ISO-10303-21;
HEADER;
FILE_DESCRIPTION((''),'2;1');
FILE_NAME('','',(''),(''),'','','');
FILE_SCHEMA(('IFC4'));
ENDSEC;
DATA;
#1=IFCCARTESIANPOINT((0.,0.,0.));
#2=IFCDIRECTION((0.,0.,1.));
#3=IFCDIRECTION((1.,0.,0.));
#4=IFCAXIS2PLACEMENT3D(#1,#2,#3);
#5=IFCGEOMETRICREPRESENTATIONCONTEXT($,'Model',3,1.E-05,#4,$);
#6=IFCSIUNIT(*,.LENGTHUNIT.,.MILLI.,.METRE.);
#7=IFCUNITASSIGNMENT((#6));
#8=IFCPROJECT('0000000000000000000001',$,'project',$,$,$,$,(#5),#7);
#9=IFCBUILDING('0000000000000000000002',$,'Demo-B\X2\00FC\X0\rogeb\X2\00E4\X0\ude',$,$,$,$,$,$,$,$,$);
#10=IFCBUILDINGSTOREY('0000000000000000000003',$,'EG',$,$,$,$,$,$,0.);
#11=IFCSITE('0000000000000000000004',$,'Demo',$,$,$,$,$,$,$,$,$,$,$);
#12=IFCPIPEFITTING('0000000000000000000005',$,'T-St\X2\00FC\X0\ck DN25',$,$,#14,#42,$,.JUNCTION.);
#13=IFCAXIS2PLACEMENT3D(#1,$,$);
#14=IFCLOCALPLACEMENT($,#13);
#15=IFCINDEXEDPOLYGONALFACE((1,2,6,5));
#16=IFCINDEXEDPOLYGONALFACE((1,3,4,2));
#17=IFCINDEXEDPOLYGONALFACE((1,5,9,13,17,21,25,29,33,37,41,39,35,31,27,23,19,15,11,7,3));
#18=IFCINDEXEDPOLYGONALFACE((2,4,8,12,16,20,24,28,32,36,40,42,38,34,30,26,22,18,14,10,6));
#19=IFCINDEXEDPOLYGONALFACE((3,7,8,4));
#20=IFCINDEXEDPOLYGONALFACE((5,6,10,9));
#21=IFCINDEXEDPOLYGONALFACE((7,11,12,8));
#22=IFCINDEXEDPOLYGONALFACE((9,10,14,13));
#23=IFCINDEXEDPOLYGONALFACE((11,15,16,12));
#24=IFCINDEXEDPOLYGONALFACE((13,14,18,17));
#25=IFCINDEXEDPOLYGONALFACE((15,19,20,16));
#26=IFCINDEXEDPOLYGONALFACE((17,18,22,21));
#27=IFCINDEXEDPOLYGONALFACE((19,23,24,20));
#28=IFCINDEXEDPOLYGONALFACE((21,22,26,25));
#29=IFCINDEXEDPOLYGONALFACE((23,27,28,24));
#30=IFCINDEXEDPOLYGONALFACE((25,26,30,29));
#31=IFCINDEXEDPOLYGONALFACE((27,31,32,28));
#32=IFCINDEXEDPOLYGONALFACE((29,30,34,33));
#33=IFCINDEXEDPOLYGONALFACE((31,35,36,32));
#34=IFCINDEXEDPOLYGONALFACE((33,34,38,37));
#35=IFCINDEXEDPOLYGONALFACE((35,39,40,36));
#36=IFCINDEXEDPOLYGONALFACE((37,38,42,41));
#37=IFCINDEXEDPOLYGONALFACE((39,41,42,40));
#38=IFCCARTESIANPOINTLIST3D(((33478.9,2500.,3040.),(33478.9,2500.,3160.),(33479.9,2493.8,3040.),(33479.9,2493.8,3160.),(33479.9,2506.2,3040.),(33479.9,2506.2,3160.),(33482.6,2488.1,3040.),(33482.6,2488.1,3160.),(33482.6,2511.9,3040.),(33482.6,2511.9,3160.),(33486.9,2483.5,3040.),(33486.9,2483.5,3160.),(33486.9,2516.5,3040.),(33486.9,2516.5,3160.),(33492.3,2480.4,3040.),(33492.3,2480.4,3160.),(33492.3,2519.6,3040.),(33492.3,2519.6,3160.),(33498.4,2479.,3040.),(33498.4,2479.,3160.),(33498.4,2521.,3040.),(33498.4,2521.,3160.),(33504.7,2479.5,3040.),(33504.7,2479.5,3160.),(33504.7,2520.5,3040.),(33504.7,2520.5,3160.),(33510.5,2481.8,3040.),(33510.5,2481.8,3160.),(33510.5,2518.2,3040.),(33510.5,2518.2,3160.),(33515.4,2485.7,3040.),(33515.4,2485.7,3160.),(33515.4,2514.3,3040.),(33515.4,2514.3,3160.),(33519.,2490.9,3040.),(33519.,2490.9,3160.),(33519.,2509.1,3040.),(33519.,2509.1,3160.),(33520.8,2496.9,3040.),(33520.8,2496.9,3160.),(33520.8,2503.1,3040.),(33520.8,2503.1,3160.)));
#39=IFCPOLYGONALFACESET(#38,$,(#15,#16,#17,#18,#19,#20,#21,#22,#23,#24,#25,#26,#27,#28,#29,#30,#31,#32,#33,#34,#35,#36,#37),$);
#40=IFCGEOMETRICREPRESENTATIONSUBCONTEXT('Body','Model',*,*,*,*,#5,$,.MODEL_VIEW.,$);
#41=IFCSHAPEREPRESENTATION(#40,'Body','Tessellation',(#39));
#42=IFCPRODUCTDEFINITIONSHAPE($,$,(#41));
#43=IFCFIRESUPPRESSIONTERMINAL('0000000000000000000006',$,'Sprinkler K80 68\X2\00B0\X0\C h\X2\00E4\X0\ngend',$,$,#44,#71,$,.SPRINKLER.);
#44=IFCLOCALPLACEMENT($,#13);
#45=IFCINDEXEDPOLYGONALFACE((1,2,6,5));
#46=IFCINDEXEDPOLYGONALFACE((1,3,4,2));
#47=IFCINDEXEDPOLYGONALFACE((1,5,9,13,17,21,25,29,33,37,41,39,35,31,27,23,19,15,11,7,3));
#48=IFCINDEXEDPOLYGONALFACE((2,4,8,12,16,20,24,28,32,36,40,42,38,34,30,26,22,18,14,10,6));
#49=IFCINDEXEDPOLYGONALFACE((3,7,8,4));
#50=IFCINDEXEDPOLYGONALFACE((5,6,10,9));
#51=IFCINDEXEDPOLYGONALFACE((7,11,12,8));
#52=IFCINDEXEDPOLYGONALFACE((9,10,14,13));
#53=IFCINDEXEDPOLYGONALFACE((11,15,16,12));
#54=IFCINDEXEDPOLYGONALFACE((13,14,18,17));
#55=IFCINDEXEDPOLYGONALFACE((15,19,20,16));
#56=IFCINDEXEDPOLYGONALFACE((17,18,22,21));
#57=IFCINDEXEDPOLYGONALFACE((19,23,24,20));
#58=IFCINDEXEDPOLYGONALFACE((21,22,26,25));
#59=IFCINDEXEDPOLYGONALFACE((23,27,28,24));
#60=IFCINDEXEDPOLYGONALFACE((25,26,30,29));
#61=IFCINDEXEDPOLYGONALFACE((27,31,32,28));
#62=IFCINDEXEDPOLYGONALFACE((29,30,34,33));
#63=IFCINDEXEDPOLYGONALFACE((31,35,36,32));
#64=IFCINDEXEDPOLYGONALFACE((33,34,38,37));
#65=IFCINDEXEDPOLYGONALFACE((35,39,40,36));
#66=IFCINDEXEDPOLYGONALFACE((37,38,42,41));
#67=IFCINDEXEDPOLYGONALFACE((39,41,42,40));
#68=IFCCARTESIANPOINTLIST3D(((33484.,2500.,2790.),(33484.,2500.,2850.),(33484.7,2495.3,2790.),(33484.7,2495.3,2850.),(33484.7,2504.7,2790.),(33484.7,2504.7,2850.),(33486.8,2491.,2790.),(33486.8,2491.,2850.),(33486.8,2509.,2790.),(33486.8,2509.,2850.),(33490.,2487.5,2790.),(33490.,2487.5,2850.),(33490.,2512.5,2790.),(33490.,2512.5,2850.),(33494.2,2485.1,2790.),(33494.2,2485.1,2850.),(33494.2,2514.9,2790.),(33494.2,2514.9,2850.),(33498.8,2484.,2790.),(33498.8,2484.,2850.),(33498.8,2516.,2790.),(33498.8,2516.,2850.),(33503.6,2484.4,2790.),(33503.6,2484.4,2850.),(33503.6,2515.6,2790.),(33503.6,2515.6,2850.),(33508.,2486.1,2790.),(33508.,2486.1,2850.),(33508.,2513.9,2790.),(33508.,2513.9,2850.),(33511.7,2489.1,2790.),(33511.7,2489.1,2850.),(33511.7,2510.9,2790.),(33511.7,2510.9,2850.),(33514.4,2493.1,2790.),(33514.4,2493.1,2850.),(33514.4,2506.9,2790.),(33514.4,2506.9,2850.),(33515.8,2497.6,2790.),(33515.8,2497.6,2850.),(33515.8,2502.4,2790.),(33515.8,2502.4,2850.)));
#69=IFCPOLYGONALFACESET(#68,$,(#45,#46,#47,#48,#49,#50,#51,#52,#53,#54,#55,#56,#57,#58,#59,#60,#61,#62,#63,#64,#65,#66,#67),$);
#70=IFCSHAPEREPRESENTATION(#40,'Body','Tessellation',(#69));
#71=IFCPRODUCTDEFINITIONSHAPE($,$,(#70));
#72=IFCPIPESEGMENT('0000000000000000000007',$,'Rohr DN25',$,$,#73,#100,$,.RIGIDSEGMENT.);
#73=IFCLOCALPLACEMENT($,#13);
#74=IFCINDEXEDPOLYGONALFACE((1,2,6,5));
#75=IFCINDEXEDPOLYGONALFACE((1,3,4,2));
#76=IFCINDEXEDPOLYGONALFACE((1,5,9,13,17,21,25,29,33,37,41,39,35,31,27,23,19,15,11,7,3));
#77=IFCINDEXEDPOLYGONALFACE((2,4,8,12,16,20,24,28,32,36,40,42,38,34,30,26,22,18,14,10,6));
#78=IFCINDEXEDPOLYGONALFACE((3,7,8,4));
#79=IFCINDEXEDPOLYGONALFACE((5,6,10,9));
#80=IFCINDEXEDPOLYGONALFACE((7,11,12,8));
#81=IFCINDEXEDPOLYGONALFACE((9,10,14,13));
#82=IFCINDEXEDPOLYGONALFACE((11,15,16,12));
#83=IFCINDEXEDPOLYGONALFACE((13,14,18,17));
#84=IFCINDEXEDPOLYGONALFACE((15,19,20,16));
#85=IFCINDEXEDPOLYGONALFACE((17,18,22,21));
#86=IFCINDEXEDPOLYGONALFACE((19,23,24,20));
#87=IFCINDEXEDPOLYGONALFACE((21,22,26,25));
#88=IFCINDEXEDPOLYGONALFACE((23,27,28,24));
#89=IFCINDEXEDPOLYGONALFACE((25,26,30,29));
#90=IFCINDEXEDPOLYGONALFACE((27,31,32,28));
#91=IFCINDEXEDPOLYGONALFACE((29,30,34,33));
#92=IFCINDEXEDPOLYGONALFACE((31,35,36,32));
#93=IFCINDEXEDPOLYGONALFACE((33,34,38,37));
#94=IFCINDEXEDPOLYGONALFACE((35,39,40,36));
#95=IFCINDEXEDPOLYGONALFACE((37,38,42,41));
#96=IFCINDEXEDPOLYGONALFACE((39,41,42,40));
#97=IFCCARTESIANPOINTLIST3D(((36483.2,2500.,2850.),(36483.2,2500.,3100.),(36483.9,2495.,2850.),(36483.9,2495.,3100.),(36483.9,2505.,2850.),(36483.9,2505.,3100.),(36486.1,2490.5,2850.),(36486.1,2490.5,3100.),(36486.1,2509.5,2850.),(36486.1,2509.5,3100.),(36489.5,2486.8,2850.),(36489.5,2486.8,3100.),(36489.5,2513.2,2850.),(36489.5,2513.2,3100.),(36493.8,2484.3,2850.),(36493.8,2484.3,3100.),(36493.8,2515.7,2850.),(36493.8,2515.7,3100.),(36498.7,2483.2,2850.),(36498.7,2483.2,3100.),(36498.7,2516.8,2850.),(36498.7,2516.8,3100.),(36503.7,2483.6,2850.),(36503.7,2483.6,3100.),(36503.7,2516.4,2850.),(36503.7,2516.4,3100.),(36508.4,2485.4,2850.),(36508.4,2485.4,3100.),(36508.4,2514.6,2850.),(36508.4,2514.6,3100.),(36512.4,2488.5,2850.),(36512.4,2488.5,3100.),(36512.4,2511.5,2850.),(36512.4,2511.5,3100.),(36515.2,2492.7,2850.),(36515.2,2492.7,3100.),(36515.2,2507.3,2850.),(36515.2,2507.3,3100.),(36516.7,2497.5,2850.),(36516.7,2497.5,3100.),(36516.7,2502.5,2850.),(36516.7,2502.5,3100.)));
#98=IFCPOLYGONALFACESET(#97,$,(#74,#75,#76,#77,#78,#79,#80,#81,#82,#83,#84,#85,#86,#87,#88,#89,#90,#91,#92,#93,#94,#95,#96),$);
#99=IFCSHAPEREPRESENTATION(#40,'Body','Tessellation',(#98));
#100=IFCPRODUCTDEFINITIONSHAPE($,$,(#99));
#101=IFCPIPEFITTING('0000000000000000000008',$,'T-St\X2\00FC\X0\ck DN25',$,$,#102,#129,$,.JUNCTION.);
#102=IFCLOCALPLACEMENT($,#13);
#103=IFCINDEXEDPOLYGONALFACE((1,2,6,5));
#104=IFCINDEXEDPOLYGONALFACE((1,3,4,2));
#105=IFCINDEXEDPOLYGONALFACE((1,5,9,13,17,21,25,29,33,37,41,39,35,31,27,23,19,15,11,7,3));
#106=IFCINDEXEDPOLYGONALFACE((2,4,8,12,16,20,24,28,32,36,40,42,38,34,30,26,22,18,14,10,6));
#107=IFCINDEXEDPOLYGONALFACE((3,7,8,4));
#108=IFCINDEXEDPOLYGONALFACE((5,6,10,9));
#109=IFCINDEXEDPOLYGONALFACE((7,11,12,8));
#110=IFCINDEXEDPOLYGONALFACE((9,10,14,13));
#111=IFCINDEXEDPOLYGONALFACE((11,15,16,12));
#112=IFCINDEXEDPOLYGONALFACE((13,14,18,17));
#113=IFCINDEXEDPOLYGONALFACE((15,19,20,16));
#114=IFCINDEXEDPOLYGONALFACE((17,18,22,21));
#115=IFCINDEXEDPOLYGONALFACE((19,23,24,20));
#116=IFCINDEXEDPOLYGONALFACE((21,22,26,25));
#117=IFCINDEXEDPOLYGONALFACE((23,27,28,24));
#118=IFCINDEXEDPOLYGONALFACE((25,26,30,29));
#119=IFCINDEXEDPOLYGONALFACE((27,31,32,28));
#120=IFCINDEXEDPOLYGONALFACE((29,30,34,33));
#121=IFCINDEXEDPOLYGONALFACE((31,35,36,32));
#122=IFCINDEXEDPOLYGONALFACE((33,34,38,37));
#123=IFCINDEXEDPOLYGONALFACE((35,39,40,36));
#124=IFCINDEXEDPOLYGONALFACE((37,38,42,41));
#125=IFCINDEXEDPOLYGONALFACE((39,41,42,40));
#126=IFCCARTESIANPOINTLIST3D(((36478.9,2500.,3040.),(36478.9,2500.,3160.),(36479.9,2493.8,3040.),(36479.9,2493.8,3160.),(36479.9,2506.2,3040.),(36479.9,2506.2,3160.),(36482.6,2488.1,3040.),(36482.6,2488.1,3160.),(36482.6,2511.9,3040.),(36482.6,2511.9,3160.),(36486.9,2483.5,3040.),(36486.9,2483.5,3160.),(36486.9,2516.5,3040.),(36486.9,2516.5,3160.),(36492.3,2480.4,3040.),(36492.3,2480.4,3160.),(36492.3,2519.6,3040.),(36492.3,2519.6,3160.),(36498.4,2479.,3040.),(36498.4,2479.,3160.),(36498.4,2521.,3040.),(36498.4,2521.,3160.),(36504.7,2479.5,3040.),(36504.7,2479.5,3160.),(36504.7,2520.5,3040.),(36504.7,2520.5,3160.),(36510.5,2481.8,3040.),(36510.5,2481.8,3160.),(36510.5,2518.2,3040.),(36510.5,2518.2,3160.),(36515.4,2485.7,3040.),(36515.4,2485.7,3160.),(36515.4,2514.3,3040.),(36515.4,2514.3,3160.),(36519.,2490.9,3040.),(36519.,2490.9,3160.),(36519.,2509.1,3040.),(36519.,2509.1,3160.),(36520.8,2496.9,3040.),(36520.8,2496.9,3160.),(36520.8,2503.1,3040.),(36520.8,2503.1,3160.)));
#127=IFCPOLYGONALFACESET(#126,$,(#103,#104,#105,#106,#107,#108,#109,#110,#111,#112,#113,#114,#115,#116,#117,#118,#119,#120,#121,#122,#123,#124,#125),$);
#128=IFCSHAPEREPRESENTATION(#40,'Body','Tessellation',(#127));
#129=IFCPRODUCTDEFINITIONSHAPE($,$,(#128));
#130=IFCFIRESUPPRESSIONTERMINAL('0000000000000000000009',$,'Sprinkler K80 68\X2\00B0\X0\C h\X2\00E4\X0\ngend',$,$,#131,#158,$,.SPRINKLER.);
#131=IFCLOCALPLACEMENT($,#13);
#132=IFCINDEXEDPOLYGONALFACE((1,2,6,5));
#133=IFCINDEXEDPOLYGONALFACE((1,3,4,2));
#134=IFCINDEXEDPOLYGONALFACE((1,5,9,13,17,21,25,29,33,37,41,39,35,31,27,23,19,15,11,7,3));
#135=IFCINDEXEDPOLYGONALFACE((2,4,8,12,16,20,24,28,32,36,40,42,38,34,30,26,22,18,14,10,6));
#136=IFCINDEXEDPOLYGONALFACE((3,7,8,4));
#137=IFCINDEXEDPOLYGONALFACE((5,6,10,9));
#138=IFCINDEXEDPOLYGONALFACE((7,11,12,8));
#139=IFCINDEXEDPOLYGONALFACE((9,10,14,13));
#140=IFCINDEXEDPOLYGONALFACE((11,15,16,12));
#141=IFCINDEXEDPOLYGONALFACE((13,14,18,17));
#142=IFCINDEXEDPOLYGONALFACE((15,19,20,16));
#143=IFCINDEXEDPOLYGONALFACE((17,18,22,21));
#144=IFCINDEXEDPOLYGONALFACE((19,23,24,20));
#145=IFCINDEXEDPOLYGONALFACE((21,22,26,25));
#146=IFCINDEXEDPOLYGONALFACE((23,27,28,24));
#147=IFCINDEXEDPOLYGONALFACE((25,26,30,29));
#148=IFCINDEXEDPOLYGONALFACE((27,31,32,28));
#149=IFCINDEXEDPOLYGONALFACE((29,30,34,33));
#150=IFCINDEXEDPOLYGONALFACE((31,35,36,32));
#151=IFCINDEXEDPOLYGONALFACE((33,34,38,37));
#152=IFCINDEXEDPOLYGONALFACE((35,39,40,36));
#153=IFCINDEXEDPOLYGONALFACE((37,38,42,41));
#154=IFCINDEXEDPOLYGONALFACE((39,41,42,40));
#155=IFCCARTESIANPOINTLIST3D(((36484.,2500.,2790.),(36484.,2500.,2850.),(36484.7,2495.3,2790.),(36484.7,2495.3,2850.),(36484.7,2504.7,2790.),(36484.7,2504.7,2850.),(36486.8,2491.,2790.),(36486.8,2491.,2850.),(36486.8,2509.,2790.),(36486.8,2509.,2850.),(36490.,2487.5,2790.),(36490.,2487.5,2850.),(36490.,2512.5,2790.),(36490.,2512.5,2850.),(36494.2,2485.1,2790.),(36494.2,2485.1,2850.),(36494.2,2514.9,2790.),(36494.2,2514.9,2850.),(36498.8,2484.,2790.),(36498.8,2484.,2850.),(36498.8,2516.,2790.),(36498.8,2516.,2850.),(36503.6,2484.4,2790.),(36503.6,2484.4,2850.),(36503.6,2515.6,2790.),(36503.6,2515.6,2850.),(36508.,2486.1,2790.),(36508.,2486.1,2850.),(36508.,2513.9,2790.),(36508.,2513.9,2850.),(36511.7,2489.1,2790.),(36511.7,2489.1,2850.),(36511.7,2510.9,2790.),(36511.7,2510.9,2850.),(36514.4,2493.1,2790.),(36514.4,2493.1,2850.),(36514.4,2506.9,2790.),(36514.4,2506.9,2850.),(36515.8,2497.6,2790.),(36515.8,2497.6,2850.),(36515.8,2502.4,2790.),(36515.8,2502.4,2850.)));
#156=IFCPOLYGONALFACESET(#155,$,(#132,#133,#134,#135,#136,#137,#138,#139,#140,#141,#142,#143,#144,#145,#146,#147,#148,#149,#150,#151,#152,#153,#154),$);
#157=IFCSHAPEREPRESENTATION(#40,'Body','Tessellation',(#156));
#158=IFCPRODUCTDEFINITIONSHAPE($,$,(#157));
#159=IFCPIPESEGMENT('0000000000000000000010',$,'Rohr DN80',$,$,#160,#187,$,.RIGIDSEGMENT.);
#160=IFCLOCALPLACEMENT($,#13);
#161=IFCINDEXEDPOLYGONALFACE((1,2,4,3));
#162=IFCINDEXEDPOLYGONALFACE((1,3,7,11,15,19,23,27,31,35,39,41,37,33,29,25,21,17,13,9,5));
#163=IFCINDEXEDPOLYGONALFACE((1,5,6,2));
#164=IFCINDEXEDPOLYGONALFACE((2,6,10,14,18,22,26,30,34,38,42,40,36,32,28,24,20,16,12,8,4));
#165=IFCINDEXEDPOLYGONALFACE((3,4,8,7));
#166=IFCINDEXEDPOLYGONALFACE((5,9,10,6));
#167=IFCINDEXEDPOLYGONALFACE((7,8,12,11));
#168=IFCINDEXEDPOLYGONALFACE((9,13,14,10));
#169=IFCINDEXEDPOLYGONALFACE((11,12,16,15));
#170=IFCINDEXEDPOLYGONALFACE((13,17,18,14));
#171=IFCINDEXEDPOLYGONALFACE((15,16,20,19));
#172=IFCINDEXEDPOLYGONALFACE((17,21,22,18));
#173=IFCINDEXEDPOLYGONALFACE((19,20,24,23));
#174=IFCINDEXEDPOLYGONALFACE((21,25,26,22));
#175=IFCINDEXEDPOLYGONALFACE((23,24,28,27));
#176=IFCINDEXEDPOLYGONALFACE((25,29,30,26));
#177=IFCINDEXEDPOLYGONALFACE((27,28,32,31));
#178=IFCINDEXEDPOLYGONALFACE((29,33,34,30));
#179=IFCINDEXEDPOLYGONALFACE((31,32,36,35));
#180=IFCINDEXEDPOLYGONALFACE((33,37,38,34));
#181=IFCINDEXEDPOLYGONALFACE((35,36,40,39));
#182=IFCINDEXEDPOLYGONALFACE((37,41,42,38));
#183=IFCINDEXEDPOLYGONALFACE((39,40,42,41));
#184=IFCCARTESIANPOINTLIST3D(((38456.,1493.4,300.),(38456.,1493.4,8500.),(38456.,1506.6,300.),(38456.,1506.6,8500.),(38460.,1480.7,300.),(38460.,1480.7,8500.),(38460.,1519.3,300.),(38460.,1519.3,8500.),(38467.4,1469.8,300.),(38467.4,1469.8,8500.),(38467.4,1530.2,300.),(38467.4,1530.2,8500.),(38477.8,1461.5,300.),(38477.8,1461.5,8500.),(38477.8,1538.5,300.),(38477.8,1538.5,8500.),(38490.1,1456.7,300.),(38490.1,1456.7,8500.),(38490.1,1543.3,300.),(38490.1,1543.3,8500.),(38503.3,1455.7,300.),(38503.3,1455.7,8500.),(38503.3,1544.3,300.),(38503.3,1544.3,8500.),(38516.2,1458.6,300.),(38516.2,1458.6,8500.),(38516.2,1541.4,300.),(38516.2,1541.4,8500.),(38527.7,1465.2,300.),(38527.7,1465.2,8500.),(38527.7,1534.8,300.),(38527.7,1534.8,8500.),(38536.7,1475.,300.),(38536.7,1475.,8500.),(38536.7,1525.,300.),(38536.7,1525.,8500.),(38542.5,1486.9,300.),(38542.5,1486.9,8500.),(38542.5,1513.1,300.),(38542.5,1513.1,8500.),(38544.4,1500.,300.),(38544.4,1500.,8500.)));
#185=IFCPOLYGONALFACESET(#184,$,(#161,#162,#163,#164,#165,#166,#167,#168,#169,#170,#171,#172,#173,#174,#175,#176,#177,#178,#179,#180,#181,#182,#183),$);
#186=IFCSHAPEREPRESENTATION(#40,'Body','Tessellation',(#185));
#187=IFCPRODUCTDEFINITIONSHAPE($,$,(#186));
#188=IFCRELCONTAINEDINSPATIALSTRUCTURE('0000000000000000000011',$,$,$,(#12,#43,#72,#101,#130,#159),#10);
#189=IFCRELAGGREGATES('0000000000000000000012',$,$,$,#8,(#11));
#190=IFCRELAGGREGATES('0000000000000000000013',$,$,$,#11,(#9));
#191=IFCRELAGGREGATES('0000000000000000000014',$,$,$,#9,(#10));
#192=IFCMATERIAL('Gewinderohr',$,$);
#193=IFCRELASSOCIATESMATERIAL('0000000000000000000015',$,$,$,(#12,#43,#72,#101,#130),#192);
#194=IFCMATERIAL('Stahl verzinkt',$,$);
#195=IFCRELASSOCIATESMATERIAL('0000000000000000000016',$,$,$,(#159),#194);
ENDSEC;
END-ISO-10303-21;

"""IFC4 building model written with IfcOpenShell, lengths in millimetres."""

from ifc_helpers import new_model, si_unit, frame, origin_with_axes, place, context, subcontext, project, spatial, circle, extrude, material, element, save


model = new_model("IFC4")

# Units and contexts
model_context = context("Model", 3, precision=1e-05, world=origin_with_axes())
body_context = subcontext(model_context, "Body", "Model", "MODEL_VIEW")
ifc_project = project(units=[si_unit("LENGTHUNIT", "METRE", prefix="MILLI")], contexts=[model_context])

# Site, building, storey
site = spatial("IfcSite", under=ifc_project, Name="Demo")
building = spatial("IfcBuilding", under=site, Name="Demo-Bürogebäude")
storey = spatial("IfcBuildingStorey", under=building, Name="EG", Elevation=0.0)

# Shared definitions
ifc_material_1 = material(Name="Gewinderohr")

# Pipe fitting
pipe_fitting_1_placement = place(None, frame((33500.0, 2500.0, 3160.0), z_axis=(0.0, 0.0, -1.0), x_axis=(-1.0, 0.0, 0.0)))
element("IfcPipeFitting", 1, at=pipe_fitting_1_placement, inside=storey, material=ifc_material_1, Name="T-Stück DN25", PredefinedType="JUNCTION", context=body_context, shape_type="SweptSolid", body=[
    extrude(circle(Radius=21.1), origin_with_axes(), (0.0, 0.0, 1.0), 120.0),
])

# Fire suppression terminal
fire_suppression_terminal_1_placement = place(None, frame((33500.0, 2500.0, 2850.0), z_axis=(0.0, 0.0, -1.0), x_axis=(-1.0, 0.0, 0.0)))
element("IfcFireSuppressionTerminal", 2, at=fire_suppression_terminal_1_placement, inside=storey, material=ifc_material_1, Name="Sprinkler K80 68°C hängend", PredefinedType="SPRINKLER", context=body_context, shape_type="SweptSolid", body=[
    extrude(circle(Radius=16.0), origin_with_axes(), (0.0, 0.0, 1.0), 60.0),
])

# Pipe segment
pipe_segment_1_placement = place(None, frame((36500.0, 2500.0, 3100.0), z_axis=(0.0, 0.0, -1.0), x_axis=(-1.0, 0.0, 0.0)))
element("IfcPipeSegment", 3, at=pipe_segment_1_placement, inside=storey, material=ifc_material_1, Name="Rohr DN25", PredefinedType="RIGIDSEGMENT", context=body_context, shape_type="SweptSolid", body=[
    extrude(circle(Radius=16.9), origin_with_axes(), (0.0, 0.0, 1.0), 250.0),
])

# Pipe fitting
pipe_fitting_2_placement = place(None, frame((36500.0, 2500.0, 3160.0), z_axis=(0.0, 0.0, -1.0), x_axis=(-1.0, 0.0, 0.0)))
element("IfcPipeFitting", 4, at=pipe_fitting_2_placement, inside=storey, material=ifc_material_1, Name="T-Stück DN25", PredefinedType="JUNCTION", context=body_context, shape_type="SweptSolid", body=[
    extrude(circle(Radius=21.1), origin_with_axes(), (0.0, 0.0, 1.0), 120.0),
])

# Fire suppression terminal
fire_suppression_terminal_2_placement = place(None, frame((36500.0, 2500.0, 2850.0), z_axis=(0.0, 0.0, -1.0), x_axis=(-1.0, 0.0, 0.0)))
element("IfcFireSuppressionTerminal", 5, at=fire_suppression_terminal_2_placement, inside=storey, material=ifc_material_1, Name="Sprinkler K80 68°C hängend", PredefinedType="SPRINKLER", context=body_context, shape_type="SweptSolid", body=[
    extrude(circle(Radius=16.0), origin_with_axes(), (0.0, 0.0, 1.0), 60.0),
])

# Pipe segment
ifc_material_2 = material(Name="Stahl verzinkt")
pipe_segment_2_placement = place(None, frame((38500.0, 1500.0, 300.0), z_axis=(0.0, 0.0, 1.0), x_axis=(1.0, 0.0, 0.0)))
element("IfcPipeSegment", 6, at=pipe_segment_2_placement, inside=storey, material=ifc_material_2, Name="Rohr DN80", PredefinedType="RIGIDSEGMENT", context=body_context, shape_type="SweptSolid", body=[
    extrude(circle(Radius=44.5), origin_with_axes(), (0.0, 0.0, 1.0), 8200.0),
])

save(model, "model.ifc")
